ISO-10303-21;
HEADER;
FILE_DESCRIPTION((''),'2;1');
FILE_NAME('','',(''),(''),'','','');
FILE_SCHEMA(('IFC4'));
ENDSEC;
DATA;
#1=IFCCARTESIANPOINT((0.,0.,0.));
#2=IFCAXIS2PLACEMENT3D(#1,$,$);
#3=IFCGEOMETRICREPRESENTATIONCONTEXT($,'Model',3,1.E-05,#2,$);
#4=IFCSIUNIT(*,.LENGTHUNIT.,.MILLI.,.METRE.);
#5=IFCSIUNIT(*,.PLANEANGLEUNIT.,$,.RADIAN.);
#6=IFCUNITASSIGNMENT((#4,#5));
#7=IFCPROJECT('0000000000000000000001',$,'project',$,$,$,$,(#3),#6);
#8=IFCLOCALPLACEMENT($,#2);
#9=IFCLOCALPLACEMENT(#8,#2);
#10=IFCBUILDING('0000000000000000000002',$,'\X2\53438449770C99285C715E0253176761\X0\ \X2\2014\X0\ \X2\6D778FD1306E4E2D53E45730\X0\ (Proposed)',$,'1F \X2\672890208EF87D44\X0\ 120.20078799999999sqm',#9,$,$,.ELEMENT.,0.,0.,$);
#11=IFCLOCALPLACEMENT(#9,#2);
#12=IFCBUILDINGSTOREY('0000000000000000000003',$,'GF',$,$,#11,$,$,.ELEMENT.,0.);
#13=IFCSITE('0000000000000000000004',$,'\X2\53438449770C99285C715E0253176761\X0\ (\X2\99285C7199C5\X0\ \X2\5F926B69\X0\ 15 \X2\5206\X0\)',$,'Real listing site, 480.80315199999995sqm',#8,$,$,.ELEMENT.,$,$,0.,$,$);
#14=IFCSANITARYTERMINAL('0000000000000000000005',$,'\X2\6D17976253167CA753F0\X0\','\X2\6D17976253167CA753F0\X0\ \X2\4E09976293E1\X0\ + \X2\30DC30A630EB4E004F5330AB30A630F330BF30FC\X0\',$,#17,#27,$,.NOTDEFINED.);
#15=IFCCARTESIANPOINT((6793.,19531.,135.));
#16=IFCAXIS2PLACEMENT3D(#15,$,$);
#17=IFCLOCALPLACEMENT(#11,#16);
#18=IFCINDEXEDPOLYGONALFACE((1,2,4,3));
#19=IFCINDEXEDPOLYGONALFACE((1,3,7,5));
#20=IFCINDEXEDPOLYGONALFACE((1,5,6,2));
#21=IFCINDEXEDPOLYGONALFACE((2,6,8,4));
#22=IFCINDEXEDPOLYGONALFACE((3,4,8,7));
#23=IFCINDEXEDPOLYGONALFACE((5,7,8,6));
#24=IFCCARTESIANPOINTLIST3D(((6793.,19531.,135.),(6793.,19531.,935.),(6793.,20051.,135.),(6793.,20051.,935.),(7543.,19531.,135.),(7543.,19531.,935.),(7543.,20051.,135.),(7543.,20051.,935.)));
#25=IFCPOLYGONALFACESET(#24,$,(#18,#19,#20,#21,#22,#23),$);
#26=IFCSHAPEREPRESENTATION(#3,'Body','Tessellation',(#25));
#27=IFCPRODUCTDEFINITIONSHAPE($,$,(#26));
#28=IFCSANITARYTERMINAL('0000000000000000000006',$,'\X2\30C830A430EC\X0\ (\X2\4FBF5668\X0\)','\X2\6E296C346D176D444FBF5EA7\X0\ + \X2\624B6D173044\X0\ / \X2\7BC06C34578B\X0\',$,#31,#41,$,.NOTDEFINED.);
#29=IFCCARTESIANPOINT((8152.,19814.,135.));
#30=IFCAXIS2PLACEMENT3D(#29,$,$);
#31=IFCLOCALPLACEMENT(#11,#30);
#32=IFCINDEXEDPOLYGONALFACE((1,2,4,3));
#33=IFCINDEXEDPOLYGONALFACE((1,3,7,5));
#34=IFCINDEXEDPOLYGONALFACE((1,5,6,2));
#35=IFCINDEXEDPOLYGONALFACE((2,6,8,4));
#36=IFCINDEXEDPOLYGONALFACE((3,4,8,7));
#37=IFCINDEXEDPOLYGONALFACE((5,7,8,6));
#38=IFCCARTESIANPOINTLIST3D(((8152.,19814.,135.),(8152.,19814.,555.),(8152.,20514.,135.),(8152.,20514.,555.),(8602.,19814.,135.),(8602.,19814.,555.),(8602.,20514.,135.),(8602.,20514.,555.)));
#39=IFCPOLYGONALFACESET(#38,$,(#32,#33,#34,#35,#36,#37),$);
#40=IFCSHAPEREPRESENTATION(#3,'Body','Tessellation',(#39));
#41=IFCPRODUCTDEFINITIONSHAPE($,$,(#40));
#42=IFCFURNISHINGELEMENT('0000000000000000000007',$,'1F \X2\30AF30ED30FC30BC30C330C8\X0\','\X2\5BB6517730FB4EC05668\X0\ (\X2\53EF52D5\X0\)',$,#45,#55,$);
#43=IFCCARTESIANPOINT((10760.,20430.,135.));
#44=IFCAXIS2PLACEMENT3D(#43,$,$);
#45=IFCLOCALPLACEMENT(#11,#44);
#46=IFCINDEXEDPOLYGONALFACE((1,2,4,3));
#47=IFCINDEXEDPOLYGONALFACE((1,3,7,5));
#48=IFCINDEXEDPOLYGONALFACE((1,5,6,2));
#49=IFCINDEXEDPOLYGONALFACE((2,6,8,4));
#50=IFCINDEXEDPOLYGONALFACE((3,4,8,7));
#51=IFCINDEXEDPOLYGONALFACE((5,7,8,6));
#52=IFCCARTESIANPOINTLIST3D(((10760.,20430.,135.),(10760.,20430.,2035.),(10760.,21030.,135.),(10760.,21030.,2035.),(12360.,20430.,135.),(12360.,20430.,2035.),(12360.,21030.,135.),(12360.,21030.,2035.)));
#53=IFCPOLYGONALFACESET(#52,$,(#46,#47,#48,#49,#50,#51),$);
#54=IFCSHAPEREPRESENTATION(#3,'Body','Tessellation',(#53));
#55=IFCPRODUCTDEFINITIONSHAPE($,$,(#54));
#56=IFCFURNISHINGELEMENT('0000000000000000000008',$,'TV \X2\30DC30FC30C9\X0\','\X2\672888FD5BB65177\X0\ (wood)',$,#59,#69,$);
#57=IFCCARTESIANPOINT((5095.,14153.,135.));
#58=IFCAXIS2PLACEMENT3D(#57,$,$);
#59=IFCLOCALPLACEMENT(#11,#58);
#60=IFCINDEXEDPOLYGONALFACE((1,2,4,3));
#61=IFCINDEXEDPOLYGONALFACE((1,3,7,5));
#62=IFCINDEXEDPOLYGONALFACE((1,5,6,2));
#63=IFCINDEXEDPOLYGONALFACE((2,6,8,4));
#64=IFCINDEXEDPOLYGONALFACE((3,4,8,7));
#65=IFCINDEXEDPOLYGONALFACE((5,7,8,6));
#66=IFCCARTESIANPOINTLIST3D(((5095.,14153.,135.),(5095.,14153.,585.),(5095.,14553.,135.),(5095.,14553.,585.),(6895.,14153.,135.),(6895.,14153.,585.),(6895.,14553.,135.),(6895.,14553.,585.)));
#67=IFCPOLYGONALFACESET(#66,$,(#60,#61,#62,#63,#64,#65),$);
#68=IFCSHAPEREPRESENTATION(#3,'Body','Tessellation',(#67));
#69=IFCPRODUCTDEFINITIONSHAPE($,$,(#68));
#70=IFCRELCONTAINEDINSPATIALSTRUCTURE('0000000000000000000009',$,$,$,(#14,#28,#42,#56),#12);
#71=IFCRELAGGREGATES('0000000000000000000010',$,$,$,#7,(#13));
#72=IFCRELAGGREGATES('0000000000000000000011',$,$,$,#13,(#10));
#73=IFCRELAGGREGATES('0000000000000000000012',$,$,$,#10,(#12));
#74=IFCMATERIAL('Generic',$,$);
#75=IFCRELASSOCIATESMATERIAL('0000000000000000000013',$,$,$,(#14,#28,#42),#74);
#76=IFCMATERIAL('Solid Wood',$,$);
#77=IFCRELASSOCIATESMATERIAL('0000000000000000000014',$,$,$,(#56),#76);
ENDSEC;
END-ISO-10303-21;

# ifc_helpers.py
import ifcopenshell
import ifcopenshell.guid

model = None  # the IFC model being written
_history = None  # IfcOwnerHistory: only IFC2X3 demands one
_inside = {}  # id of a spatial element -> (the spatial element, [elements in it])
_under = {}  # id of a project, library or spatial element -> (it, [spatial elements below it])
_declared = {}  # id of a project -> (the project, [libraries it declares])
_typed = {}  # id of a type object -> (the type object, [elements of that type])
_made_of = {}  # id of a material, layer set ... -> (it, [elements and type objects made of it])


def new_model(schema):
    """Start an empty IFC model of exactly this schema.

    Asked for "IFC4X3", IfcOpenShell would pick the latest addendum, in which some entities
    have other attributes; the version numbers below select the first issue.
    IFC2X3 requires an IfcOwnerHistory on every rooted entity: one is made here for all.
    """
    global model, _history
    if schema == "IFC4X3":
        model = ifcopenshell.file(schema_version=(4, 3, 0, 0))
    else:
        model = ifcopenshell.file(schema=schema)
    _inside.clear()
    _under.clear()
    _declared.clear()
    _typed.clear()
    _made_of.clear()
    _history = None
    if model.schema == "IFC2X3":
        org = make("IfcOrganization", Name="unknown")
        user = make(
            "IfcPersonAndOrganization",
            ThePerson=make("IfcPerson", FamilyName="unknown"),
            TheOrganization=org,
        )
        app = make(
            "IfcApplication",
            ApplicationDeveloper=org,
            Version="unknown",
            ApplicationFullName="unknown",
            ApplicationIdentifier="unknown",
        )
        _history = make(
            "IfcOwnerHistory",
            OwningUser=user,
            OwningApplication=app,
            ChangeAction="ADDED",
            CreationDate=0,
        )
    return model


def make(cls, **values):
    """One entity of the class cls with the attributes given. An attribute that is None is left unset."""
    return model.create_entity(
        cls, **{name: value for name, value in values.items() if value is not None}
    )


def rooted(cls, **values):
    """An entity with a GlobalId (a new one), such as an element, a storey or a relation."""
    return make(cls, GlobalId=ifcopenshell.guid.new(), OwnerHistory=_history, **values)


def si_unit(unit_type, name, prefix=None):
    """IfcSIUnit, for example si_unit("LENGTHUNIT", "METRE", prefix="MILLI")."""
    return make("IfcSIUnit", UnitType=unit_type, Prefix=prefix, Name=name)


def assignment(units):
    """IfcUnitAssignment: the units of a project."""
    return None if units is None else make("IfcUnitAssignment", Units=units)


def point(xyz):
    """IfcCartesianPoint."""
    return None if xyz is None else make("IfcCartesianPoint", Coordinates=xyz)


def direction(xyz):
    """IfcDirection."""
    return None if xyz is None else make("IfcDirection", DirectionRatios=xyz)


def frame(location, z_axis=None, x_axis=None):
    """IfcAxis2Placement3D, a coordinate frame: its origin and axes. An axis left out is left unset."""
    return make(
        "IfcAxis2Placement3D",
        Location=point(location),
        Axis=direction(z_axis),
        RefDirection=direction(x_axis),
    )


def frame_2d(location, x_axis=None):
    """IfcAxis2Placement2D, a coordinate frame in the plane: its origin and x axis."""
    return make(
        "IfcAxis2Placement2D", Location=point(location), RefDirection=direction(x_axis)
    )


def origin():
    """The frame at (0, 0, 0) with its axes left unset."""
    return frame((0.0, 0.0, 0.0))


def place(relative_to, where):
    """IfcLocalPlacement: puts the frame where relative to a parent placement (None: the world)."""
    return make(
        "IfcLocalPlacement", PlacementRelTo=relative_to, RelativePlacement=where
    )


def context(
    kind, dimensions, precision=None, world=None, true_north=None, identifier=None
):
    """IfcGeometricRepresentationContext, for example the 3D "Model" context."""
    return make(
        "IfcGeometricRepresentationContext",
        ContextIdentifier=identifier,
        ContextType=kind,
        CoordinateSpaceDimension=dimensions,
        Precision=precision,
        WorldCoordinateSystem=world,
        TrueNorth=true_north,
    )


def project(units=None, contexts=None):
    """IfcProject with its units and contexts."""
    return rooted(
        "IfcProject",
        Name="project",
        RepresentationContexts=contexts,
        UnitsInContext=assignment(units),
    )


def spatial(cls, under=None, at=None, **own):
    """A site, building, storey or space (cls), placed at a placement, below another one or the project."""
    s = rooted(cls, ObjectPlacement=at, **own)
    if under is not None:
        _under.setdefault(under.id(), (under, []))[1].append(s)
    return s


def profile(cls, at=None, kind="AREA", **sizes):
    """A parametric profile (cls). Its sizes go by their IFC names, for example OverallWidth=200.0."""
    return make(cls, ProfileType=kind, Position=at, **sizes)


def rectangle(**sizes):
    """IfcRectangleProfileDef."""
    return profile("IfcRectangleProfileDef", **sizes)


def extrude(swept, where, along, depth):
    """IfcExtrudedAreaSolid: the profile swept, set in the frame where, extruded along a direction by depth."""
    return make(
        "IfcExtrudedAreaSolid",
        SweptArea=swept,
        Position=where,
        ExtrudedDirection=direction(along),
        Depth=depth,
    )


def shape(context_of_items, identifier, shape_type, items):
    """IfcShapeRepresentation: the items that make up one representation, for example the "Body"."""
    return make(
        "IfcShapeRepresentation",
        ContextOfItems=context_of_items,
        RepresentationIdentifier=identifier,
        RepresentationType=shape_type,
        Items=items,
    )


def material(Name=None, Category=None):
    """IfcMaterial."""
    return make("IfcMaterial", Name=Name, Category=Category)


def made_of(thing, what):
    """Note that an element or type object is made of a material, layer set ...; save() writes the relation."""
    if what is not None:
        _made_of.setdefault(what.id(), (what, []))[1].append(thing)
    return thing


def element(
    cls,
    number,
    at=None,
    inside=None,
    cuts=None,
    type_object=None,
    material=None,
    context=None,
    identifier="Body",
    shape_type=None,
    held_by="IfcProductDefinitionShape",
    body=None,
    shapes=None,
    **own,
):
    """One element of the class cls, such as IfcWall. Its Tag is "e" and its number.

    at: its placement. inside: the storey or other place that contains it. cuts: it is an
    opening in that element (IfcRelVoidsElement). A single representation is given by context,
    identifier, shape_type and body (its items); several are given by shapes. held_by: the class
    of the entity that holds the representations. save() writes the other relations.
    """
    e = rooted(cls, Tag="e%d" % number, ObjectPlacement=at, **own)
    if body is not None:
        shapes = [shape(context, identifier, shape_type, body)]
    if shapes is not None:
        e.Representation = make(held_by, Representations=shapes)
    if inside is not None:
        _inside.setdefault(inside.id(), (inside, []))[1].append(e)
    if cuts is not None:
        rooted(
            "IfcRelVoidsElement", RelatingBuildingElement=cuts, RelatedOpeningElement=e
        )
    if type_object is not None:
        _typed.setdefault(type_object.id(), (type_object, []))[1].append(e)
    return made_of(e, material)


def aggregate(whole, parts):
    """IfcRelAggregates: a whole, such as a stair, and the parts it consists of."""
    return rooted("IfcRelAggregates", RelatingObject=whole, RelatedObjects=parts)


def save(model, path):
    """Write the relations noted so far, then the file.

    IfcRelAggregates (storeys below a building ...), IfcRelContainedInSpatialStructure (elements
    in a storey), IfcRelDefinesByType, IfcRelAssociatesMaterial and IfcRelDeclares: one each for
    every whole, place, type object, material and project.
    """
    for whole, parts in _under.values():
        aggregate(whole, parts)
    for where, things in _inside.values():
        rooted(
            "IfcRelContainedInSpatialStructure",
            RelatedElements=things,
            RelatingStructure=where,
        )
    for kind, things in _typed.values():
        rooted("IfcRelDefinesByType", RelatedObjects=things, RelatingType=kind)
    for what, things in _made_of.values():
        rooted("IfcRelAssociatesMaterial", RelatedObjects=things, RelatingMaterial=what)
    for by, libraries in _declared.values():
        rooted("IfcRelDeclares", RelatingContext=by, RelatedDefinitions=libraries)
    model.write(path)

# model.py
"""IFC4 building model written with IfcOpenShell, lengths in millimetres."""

from ifc_helpers import new_model, si_unit, frame, frame_2d, origin, place, context, project, spatial, rectangle, extrude, material, element, save


model = new_model("IFC4")

# Units and contexts
model_context = context("Model", 3, precision=1e-05, world=origin())
ifc_project = project(units=[si_unit("LENGTHUNIT", "METRE", prefix="MILLI"), si_unit("PLANEANGLEUNIT", "RADIAN")], contexts=[model_context])

# Site, building, storey
site_placement = place(None, origin())
site = spatial("IfcSite", under=ifc_project, at=site_placement, Name="千葉県館山市北条 (館山駅 徒歩 15 分)", ObjectType="Real listing site, 480.80315199999995sqm", CompositionType="ELEMENT", RefElevation=0.0)
building_placement = place(site_placement, origin())
building = spatial("IfcBuilding", under=site, at=building_placement, Name="千葉県館山市北条 — 海近の中古地 (Proposed)", ObjectType="1F 木造軸組 120.20078799999999sqm", CompositionType="ELEMENT", ElevationOfRefHeight=0.0, ElevationOfTerrain=0.0)
storey_placement = place(building_placement, origin())
storey = spatial("IfcBuildingStorey", under=building, at=storey_placement, Name="GF", CompositionType="ELEMENT", Elevation=0.0)

# Shared definitions
ifc_material_1 = material(Name="Solid Wood")

# Sanitary terminals
ifc_material_2 = material(Name="Generic")
sanitary_terminal_1_placement = place(storey_placement, frame((6793.0, 19531.0, 135.0)))
element("IfcSanitaryTerminal", 1, at=sanitary_terminal_1_placement, inside=storey, material=ifc_material_2, Name="洗面化粧台", Description="洗面化粧台 三面鏡 + ボウル一体カウンター", PredefinedType="NOTDEFINED", context=model_context, shape_type="SweptSolid", body=[
    extrude(rectangle(XDim=750.0, YDim=520.0, at=frame_2d((375.0, 260.0))), frame((6793.0, 19531.0, 135.0)), (0.0, 0.0, 1.0), 800.0),
])
sanitary_terminal_2_placement = place(storey_placement, frame((8152.0, 19814.0, 135.0)))
element("IfcSanitaryTerminal", 2, at=sanitary_terminal_2_placement, inside=storey, material=ifc_material_2, Name="トイレ (便器)", Description="温水洗浄便座 + 手洗い / 節水型", PredefinedType="NOTDEFINED", context=model_context, shape_type="SweptSolid", body=[
    extrude(rectangle(XDim=450.0, YDim=700.0, at=frame_2d((225.0, 350.0))), frame((8152.0, 19814.0, 135.0)), (0.0, 0.0, 1.0), 420.0),
])

# Furnishing elements
furnishing_1_placement = place(storey_placement, frame((10760.0, 20430.0, 135.0)))
element("IfcFurnishingElement", 3, at=furnishing_1_placement, inside=storey, material=ifc_material_2, Name="1F クローゼット", Description="家具・什器 (可動)", context=model_context, shape_type="SweptSolid", body=[
    extrude(rectangle(XDim=1600.0, YDim=600.0, at=frame_2d((800.0, 300.0))), frame((10760.0, 20430.0, 135.0)), (0.0, 0.0, 1.0), 1900.0),
])
furnishing_2_placement = place(storey_placement, frame((5095.0, 14153.0, 135.0)))
element("IfcFurnishingElement", 4, at=furnishing_2_placement, inside=storey, material=ifc_material_1, Name="TV ボード", Description="木製家具 (wood)", context=model_context, shape_type="SweptSolid", body=[
    extrude(rectangle(XDim=1800.0, YDim=400.0, at=frame_2d((900.0, 200.0))), frame((5095.0, 14153.0, 135.0)), (0.0, 0.0, 1.0), 450.0),
])

save(model, "model.ifc")
